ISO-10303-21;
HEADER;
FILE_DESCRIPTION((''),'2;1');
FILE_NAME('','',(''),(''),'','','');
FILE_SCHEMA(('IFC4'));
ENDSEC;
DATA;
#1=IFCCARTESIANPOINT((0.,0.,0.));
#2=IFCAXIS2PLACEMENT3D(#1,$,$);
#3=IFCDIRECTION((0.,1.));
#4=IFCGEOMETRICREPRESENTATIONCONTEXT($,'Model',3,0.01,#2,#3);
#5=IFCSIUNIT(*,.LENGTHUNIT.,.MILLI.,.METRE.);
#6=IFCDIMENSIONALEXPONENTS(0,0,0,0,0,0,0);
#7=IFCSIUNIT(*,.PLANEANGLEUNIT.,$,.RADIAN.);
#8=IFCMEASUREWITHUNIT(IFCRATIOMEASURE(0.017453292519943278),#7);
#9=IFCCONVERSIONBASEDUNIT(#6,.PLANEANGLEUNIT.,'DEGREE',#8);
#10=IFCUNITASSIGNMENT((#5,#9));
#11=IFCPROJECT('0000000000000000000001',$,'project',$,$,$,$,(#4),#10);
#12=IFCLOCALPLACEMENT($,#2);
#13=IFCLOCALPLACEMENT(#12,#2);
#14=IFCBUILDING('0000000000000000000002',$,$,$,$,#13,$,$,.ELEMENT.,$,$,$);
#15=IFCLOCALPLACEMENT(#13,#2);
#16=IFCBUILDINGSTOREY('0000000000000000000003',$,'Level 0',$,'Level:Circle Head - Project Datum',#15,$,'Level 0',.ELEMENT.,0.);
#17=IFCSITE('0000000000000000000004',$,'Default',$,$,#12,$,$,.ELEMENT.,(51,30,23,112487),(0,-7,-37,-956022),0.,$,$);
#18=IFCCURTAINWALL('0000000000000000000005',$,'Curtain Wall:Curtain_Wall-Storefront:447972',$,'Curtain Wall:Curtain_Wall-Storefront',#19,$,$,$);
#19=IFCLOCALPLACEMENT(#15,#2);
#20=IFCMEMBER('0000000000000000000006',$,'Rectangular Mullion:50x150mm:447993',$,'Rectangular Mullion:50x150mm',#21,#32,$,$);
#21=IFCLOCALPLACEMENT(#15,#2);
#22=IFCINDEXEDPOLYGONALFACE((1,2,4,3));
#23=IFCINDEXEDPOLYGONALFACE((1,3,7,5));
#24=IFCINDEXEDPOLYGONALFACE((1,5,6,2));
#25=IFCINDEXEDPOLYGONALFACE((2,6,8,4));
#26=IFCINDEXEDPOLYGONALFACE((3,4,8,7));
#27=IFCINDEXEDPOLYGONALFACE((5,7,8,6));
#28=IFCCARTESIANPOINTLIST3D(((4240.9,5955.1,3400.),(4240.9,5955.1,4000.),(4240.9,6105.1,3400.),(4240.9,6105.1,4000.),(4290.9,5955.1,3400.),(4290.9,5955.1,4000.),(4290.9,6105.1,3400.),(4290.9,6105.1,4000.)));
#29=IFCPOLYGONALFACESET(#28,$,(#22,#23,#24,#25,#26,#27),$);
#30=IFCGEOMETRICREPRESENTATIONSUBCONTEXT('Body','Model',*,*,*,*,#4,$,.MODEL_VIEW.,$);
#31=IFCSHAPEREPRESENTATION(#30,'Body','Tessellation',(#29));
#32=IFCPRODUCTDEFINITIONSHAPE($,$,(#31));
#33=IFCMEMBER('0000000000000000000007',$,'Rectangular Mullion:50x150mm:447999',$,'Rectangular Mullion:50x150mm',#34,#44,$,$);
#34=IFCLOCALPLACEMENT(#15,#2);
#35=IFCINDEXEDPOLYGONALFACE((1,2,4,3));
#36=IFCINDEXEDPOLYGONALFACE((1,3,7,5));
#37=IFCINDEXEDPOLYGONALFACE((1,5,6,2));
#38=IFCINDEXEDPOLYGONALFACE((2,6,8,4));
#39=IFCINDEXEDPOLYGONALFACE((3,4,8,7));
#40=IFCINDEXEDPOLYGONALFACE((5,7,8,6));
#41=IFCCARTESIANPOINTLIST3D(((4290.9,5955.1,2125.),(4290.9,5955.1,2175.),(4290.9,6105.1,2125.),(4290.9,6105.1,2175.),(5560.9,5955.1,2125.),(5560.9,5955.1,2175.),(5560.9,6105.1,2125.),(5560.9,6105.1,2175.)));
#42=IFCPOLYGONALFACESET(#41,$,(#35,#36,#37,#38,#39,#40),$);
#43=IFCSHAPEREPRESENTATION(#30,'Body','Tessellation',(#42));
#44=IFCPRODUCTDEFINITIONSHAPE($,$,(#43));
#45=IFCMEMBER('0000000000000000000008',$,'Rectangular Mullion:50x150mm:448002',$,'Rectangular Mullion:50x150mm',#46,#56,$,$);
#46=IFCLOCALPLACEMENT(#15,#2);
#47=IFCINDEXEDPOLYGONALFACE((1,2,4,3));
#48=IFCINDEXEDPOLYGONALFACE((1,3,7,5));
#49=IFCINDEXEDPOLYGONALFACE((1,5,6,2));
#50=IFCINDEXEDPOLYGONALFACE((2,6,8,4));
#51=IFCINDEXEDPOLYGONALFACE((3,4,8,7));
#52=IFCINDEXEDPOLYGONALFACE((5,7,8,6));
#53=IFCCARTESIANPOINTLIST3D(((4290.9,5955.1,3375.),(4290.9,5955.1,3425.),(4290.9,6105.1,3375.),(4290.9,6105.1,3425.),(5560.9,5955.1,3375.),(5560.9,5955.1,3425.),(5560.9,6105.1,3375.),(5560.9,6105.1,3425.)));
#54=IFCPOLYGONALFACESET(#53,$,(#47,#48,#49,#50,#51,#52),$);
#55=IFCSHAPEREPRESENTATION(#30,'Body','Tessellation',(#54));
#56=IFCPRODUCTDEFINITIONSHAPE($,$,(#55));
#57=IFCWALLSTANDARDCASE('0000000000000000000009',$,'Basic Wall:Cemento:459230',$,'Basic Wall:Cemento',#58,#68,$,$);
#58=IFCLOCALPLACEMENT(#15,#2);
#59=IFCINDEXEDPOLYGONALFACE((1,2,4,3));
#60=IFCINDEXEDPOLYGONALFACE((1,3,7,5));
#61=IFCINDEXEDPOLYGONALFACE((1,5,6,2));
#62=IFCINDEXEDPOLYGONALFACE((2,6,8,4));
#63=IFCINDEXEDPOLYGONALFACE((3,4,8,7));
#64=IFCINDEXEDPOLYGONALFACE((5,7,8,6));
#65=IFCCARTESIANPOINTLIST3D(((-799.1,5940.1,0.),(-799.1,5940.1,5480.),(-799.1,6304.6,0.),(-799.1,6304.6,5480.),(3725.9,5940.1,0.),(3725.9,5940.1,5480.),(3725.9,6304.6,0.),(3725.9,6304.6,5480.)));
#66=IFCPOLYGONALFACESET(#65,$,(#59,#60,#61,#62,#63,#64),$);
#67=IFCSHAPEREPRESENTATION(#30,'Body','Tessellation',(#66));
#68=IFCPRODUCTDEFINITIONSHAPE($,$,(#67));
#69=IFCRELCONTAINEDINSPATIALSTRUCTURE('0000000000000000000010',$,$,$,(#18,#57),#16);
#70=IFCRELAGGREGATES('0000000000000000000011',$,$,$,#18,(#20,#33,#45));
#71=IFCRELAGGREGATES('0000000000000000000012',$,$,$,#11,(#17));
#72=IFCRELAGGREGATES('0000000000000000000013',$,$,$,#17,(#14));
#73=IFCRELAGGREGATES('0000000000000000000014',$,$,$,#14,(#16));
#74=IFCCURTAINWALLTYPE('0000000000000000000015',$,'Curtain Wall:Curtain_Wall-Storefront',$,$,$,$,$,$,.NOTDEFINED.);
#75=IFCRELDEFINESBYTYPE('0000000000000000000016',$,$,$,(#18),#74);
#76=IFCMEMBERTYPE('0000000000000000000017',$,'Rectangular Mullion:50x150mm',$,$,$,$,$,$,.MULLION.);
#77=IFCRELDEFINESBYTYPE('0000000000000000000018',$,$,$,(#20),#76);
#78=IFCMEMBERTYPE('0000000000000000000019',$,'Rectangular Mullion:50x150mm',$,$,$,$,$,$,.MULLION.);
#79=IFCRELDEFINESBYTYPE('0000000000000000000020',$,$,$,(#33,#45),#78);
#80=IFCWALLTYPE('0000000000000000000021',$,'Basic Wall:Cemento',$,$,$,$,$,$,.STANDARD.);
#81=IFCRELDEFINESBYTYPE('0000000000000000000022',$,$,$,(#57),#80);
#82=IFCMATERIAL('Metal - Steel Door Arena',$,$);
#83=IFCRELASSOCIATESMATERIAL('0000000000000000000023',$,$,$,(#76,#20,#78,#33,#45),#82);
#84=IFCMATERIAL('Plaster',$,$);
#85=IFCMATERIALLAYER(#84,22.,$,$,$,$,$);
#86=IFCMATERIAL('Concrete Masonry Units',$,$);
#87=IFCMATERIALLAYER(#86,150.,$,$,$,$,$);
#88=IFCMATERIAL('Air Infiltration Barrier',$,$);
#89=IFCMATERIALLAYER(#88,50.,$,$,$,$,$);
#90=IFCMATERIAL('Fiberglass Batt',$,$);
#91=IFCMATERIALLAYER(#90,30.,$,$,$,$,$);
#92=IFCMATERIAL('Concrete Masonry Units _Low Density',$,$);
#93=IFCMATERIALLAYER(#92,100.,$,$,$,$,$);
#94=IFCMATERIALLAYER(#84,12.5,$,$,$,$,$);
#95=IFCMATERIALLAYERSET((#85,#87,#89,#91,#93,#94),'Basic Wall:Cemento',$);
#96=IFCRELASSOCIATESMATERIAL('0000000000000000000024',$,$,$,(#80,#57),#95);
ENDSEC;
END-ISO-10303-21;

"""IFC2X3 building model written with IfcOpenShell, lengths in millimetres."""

from ifc_helpers import new_model, entity, si_unit, converted_unit, direction, frame, frame_2d, origin, origin_2d_with_axis, place, context, subcontext, project, spatial, rectangle, extrude, source, transform, mapped, material, layer, layer_set, layer_usage, type_object, type_shapes, element, aggregate, save


model = new_model("IFC2X3")

# Units and contexts
model_context = context("Model", 3, precision=0.01, world=origin(), true_north=direction((0.0, 1.0)))
body_context = subcontext(model_context, "Body", "Model", "MODEL_VIEW")
ifc_project = project(units=[si_unit("LENGTHUNIT", "METRE", prefix="MILLI"), converted_unit("PLANEANGLEUNIT", "DEGREE", entity("IfcRatioMeasure", 0.017453292519943278), si_unit("PLANEANGLEUNIT", "RADIAN"), dimensions=[0, 0, 0, 0, 0, 0, 0])], contexts=[model_context])

# Site, building, storey
site_placement = place(None, origin())
site = spatial("IfcSite", under=ifc_project, at=site_placement, Name="Default", CompositionType="ELEMENT", RefLatitude=(51, 30, 23, 112487), RefLongitude=(0, -7, -37, -956022), RefElevation=0.0)
building_placement = place(site_placement, origin())
building = spatial("IfcBuilding", under=site, at=building_placement, CompositionType="ELEMENT")
storey_placement = place(building_placement, origin())
storey = spatial("IfcBuildingStorey", under=building, at=storey_placement, Name="Level 0", ObjectType="Level:Circle Head - Project Datum", LongName="Level 0", CompositionType="ELEMENT", Elevation=0.0)

# Shared definitions
ifc_material_1 = material(Name="Plaster")

# Curtain wall, members
curtain_wall_type = type_object("IfcCurtainWallType", Name="Curtain Wall:Curtain_Wall-Storefront", PredefinedType="NOTDEFINED")
curtain_wall_placement = place(storey_placement, origin())
curtain_wall = element("IfcCurtainWall", 1, at=curtain_wall_placement, inside=storey, type_object=curtain_wall_type, Name="Curtain Wall:Curtain_Wall-Storefront:447972", ObjectType="Curtain Wall:Curtain_Wall-Storefront")
ifc_material_2 = material(Name="Metal - Steel Door Arena")
member_type_1 = type_object("IfcMemberType", Name="Rectangular Mullion:50x150mm", PredefinedType="MULLION", material=ifc_material_2)
shared_shape_1 = source(origin(), body_context, "Body", "SweptSolid", [
    extrude(rectangle(XDim=150.0, YDim=50.0, at=origin_2d_with_axis()), frame((-25.0, 0.0, -600.0), z_axis=(0.0, 0.0, 1.0), x_axis=(0.0, -1.0, 0.0)), (0.0, 0.0, 1.0), 600.0),
])
type_shapes(member_type_1, [shared_shape_1])
member_1_placement = place(curtain_wall_placement, frame((4240.9, 6030.1, 3400.0), z_axis=(0.0, 0.0, -1.0), x_axis=(-1.0, 0.0, 0.0)))
member_1 = element("IfcMember", 2, at=member_1_placement, type_object=member_type_1, material=ifc_material_2, Name="Rectangular Mullion:50x150mm:447993", ObjectType="Rectangular Mullion:50x150mm", context=body_context, shape_type="MappedRepresentation", body=[
    mapped(shared_shape_1, transform((0.0, 0.0, 0.0), scale=1.0)),
])
member_type_2 = type_object("IfcMemberType", Name="Rectangular Mullion:50x150mm", PredefinedType="MULLION", material=ifc_material_2)
shared_shape_2 = source(origin(), body_context, "Body", "SweptSolid", [
    extrude(rectangle(XDim=150.0, YDim=50.0, at=origin_2d_with_axis()), frame((0.0, 0.0, -1270.0), z_axis=(0.0, 0.0, 1.0), x_axis=(0.0, -1.0, 0.0)), (0.0, 0.0, 1.0), 1270.0),
])
type_shapes(member_type_2, [shared_shape_2])
member_2_placement = place(curtain_wall_placement, frame((4290.9, 6030.1, 2150.0), z_axis=(-1.0, 0.0, 0.0), x_axis=(0.0, 0.0, 1.0)))
member_2 = element("IfcMember", 3, at=member_2_placement, type_object=member_type_2, material=ifc_material_2, Name="Rectangular Mullion:50x150mm:447999", ObjectType="Rectangular Mullion:50x150mm", context=body_context, shape_type="MappedRepresentation", body=[
    mapped(shared_shape_2, transform((0.0, 0.0, 0.0), scale=1.0)),
])
member_3_placement = place(curtain_wall_placement, frame((4290.9, 6030.1, 3400.0), z_axis=(-1.0, 0.0, 0.0), x_axis=(0.0, 0.0, 1.0)))
member_3 = element("IfcMember", 4, at=member_3_placement, type_object=member_type_2, material=ifc_material_2, Name="Rectangular Mullion:50x150mm:448002", ObjectType="Rectangular Mullion:50x150mm", context=body_context, shape_type="MappedRepresentation", body=[
    mapped(shared_shape_2, transform((0.0, 0.0, 0.0), scale=1.0)),
])
aggregate(curtain_wall, [member_1, member_2, member_3])

# Wall
ifc_layer_1 = layer(ifc_material_1, 22.0)
ifc_material_3 = material(Name="Concrete Masonry Units")
ifc_layer_2 = layer(ifc_material_3, 150.0)
ifc_material_4 = material(Name="Air Infiltration Barrier")
ifc_layer_3 = layer(ifc_material_4, 50.0)
ifc_material_5 = material(Name="Fiberglass Batt")
ifc_layer_4 = layer(ifc_material_5, 30.0)
ifc_material_6 = material(Name="Concrete Masonry Units _Low Density")
ifc_layer_5 = layer(ifc_material_6, 100.0)
ifc_layer_6 = layer(ifc_material_1, 12.5)
ifc_layer_set = layer_set([ifc_layer_1, ifc_layer_2, ifc_layer_3, ifc_layer_4, ifc_layer_5, ifc_layer_6], Name="Basic Wall:Cemento")
ifc_layer_usage = layer_usage(ifc_layer_set, "AXIS2", "NEGATIVE", 182.3)
wall_type = type_object("IfcWallType", Name="Basic Wall:Cemento", PredefinedType="STANDARD", material=ifc_layer_set)
wall_placement = place(storey_placement, frame((3725.9, 6122.4, 0.0), z_axis=(0.0, 0.0, 1.0), x_axis=(-1.0, 0.0, 0.0)))
element("IfcWallStandardCase", 5, at=wall_placement, inside=storey, type_object=wall_type, material=ifc_layer_usage, Name="Basic Wall:Cemento:459230", ObjectType="Basic Wall:Cemento", context=body_context, shape_type="SweptSolid", body=[
    extrude(rectangle(XDim=4525.0, YDim=364.5, at=frame_2d((2262.5, 0.0), x_axis=(-1.0, 0.0))), origin(), (0.0, 0.0, 1.0), 5480.0),
])

save(model, "model.ifc")
